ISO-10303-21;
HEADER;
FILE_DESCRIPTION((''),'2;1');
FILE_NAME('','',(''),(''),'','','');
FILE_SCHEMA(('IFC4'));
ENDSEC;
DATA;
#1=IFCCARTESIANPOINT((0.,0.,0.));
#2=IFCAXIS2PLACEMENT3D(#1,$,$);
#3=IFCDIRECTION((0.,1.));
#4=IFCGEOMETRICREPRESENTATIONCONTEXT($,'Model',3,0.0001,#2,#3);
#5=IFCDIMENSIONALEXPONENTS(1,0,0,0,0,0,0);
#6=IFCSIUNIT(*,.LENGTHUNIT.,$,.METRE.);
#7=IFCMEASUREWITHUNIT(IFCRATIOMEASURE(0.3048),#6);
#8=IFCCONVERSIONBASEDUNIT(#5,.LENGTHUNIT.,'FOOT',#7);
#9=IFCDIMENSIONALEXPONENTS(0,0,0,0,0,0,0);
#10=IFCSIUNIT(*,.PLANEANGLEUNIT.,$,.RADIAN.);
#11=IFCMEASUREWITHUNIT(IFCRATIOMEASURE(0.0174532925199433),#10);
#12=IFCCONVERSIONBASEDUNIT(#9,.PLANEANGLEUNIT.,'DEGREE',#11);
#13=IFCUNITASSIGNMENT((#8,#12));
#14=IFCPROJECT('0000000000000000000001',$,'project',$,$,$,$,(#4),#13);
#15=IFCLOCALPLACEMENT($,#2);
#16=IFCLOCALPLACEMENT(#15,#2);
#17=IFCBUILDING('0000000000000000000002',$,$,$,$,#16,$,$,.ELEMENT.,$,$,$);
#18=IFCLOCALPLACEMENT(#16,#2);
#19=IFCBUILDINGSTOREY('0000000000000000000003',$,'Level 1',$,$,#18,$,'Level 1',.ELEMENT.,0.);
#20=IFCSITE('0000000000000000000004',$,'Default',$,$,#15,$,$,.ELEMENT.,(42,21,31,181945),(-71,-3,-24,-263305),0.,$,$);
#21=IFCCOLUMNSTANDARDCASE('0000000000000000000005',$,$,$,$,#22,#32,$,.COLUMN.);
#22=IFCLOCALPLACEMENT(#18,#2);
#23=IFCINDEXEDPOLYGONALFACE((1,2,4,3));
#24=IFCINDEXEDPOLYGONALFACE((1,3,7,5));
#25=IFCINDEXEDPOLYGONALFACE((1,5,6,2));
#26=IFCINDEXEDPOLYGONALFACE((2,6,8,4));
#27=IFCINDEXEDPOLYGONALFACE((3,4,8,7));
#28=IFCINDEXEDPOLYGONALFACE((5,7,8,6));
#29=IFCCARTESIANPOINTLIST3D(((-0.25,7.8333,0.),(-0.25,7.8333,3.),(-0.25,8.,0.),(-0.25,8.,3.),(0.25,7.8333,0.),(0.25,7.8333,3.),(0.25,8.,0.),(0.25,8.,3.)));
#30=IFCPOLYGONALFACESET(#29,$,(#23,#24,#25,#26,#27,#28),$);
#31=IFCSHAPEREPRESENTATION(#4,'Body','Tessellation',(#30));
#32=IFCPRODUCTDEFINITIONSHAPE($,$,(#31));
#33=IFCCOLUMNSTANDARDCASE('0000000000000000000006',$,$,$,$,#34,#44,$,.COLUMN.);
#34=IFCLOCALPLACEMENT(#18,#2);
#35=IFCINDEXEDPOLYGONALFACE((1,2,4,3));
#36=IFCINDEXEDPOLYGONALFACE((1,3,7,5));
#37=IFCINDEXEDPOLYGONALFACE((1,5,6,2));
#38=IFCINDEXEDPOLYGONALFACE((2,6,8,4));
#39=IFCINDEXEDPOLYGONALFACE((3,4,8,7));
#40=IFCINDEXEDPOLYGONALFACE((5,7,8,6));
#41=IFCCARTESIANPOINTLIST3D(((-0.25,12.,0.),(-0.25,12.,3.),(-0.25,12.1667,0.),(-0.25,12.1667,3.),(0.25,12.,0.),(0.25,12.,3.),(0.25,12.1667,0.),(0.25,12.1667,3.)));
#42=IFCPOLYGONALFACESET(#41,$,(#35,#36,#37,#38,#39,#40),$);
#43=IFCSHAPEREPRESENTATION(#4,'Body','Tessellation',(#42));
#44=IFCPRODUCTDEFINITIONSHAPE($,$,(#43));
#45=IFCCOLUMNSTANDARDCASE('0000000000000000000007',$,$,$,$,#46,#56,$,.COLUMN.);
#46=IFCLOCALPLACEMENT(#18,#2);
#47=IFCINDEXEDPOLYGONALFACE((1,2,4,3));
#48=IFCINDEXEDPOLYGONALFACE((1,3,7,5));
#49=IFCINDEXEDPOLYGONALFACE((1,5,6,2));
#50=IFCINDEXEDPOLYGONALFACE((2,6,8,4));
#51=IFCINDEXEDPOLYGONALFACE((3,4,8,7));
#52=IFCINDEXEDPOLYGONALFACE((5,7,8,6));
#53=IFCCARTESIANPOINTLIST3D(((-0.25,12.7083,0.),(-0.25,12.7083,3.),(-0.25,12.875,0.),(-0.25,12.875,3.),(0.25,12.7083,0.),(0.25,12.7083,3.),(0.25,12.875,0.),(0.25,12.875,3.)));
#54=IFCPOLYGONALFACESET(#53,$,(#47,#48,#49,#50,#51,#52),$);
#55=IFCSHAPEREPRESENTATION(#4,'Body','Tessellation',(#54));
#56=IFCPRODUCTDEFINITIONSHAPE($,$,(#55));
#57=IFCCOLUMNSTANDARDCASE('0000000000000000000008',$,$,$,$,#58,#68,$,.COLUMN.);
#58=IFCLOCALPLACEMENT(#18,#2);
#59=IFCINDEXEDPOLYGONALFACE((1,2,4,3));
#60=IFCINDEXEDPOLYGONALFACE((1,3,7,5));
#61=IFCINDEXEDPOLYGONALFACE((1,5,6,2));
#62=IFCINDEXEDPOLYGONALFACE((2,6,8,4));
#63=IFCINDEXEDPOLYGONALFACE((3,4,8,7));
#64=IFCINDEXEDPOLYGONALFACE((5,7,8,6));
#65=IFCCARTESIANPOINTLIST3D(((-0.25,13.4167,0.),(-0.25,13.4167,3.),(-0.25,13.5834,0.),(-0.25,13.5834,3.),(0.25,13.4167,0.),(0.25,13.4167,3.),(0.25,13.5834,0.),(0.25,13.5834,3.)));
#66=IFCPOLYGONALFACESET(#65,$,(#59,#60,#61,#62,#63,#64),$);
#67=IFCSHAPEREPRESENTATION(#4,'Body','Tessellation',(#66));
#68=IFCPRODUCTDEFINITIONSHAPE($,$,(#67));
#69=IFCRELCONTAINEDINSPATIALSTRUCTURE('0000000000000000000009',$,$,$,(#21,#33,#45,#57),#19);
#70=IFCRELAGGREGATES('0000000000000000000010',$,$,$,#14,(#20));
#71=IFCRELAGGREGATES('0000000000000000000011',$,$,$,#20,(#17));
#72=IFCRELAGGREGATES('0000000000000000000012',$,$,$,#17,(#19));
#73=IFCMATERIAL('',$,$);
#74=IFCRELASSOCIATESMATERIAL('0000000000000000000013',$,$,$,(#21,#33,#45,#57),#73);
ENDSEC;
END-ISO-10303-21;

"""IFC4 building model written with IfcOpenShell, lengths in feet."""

from ifc_helpers import new_model, entity, si_unit, converted_unit, direction, frame, origin, place, context, project, spatial, rectangle, extrude, material, element, save


model = new_model("IFC4")

# Units and contexts
model_context = context("Model", 3, precision=0.0001, world=origin(), true_north=direction((0.0, 1.0)))
ifc_project = project(units=[converted_unit("LENGTHUNIT", "FOOT", entity("IfcRatioMeasure", 0.3048), si_unit("LENGTHUNIT", "METRE"), dimensions=[1, 0, 0, 0, 0, 0, 0]), converted_unit("PLANEANGLEUNIT", "DEGREE", entity("IfcRatioMeasure", 0.0174532925199433), si_unit("PLANEANGLEUNIT", "RADIAN"), dimensions=[0, 0, 0, 0, 0, 0, 0])], contexts=[model_context])

# Site, building, storey
site_placement = place(None, origin())
site = spatial("IfcSite", under=ifc_project, at=site_placement, Name="Default", CompositionType="ELEMENT", RefLatitude=(42, 21, 31, 181945), RefLongitude=(-71, -3, -24, -263305), RefElevation=0.0)
building_placement = place(site_placement, origin())
building = spatial("IfcBuilding", under=site, at=building_placement, CompositionType="ELEMENT")
storey_placement = place(building_placement, origin())
storey = spatial("IfcBuildingStorey", under=building, at=storey_placement, Name="Level 1", LongName="Level 1", CompositionType="ELEMENT", Elevation=0.0)

# Columns
placement = place(storey_placement, frame((0.0, -0.25, 0.0), z_axis=(0.0, 0.0, 1.0), x_axis=(0.0, 1.0, 0.0)))
ifc_material_1 = material(Name="")
for number, where, z_axis, x_axis in (
    (1, (8.1667, 0.0, 0.0), (0.0, 0.0, 1.0), (1.0, 0.0, 0.0)),
    (2, (12.3334, 0.0, 0.0), (0.0, 0.0, 1.0), (1.0, 0.0, 0.0)),
    (3, (13.0417, 0.0, 0.0), (0.0, 0.0, 1.0), (1.0, 0.0, 0.0)),
    (4, (13.75, 0.0, 0.0), (0.0, 0.0, 1.0), (1.0, 0.0, 0.0)),
):
    element("IfcColumnStandardCase", number, at=place(placement, frame(where, z_axis=z_axis, x_axis=x_axis)), inside=storey, material=ifc_material_1, PredefinedType="COLUMN", context=model_context, shape_type="SweptSolid", body=[
        extrude(rectangle(XDim=0.1667, YDim=0.5), origin(), (0.0, 0.0, 1.0), 3.0),
    ])

save(model, "model.ifc")
